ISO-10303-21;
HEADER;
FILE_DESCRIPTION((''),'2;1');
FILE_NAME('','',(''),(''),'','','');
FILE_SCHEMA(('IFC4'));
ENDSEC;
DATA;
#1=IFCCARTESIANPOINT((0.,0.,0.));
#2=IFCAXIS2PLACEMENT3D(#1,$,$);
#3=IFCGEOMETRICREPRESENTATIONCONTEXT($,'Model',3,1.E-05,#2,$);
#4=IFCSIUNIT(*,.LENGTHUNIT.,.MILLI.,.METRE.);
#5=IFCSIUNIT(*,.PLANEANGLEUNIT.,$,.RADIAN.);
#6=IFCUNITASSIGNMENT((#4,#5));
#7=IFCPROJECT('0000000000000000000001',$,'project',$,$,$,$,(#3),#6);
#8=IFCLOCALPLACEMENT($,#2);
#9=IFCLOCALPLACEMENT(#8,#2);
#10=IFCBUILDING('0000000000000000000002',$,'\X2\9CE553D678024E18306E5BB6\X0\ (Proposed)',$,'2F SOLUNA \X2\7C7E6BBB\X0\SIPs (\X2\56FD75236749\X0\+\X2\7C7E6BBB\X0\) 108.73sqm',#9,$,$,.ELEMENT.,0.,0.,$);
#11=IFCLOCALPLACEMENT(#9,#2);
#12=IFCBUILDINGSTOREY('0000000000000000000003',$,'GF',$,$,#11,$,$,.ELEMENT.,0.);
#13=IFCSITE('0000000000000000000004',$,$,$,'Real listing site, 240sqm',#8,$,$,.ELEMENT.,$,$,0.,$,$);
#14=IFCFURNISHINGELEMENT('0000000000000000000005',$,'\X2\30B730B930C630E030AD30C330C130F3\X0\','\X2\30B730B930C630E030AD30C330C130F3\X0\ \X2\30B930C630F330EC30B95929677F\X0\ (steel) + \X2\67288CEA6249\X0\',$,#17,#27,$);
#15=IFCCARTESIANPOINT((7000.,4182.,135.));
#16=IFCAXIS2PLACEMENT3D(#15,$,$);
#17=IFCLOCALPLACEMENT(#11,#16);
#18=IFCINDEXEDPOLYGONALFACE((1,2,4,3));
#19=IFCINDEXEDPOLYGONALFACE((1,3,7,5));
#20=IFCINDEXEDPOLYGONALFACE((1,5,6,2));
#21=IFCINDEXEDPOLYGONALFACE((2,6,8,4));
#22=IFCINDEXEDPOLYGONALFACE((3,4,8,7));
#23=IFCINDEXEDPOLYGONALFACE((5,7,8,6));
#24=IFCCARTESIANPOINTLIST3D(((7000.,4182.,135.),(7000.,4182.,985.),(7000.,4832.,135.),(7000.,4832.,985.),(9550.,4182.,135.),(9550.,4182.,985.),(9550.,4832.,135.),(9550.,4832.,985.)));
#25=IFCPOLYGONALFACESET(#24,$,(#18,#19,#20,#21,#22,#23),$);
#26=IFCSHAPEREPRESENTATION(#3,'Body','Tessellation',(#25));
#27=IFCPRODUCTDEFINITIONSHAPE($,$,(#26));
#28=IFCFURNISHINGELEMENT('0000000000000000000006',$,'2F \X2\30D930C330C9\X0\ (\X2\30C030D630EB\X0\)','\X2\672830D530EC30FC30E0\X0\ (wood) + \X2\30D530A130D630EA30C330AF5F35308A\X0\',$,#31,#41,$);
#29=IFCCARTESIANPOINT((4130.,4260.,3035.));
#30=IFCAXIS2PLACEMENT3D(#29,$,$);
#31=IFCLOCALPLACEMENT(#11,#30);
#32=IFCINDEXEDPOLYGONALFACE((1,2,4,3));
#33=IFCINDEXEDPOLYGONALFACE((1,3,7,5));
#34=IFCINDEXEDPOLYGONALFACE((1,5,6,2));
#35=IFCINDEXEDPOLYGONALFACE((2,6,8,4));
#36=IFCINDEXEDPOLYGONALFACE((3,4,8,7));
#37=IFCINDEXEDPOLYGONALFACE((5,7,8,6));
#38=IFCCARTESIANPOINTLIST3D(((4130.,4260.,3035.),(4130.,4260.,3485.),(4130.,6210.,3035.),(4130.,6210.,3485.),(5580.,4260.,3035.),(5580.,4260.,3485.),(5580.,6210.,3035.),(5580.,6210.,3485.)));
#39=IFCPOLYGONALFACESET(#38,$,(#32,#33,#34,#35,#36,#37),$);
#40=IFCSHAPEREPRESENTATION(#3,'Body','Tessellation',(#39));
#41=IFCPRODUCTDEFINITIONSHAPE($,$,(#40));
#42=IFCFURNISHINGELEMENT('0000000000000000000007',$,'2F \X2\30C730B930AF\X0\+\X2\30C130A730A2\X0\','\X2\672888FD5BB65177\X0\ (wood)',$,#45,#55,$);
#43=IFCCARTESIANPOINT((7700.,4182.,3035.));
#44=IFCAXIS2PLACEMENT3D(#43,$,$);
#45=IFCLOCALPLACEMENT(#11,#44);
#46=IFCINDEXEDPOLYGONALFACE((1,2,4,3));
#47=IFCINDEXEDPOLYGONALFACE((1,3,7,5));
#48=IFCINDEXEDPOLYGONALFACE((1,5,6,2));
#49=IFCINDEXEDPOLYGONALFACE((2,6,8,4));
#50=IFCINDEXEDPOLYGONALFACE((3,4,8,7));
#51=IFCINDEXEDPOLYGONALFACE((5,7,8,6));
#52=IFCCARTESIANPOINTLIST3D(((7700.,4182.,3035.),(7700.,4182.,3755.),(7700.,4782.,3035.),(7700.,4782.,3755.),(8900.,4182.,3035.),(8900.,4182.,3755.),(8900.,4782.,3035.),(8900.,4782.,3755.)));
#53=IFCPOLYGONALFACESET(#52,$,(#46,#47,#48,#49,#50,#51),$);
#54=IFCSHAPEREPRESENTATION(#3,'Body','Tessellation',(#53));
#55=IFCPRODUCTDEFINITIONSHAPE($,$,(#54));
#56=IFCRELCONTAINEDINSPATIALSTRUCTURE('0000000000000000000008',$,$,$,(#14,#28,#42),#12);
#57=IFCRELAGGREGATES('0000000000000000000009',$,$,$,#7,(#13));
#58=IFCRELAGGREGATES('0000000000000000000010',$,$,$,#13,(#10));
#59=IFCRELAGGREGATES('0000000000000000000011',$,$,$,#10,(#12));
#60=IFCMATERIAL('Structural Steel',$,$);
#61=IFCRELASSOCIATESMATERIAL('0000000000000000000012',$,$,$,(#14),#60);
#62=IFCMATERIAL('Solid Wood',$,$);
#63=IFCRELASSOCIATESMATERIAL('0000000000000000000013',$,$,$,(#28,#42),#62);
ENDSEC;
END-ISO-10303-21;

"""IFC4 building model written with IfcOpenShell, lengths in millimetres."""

from ifc_helpers import new_model, si_unit, frame, frame_2d, origin, place, context, project, spatial, rectangle, extrude, material, element, save


model = new_model("IFC4")

# Units and contexts
model_context = context("Model", 3, precision=1e-05, world=origin())
ifc_project = project(units=[si_unit("LENGTHUNIT", "METRE", prefix="MILLI"), si_unit("PLANEANGLEUNIT", "RADIAN")], contexts=[model_context])

# Site, building, storey
site_placement = place(None, origin())
site = spatial("IfcSite", under=ifc_project, at=site_placement, ObjectType="Real listing site, 240sqm", CompositionType="ELEMENT", RefElevation=0.0)
building_placement = place(site_placement, origin())
building = spatial("IfcBuilding", under=site, at=building_placement, Name="鳥取砂丘の家 (Proposed)", ObjectType="2F SOLUNA 籾殻SIPs (国産杉+籾殻) 108.73sqm", CompositionType="ELEMENT", ElevationOfRefHeight=0.0, ElevationOfTerrain=0.0)
storey_placement = place(building_placement, origin())
storey = spatial("IfcBuildingStorey", under=building, at=storey_placement, Name="GF", CompositionType="ELEMENT", Elevation=0.0)

# Shared definitions
ifc_material_1 = material(Name="Solid Wood")

# Furnishing elements
ifc_material_2 = material(Name="Structural Steel")
furnishing_1_placement = place(storey_placement, frame((7000.0, 4182.0, 135.0)))
element("IfcFurnishingElement", 1, at=furnishing_1_placement, inside=storey, material=ifc_material_2, Name="システムキッチン", Description="システムキッチン ステンレス天板 (steel) + 木質扉", context=model_context, shape_type="SweptSolid", body=[
    extrude(rectangle(XDim=2550.0, YDim=650.0, at=frame_2d((1275.0, 325.0))), frame((7000.0, 4182.0, 135.0)), (0.0, 0.0, 1.0), 850.0),
])
furnishing_2_placement = place(storey_placement, frame((4130.0, 4260.0, 3035.0)))
element("IfcFurnishingElement", 2, at=furnishing_2_placement, inside=storey, material=ifc_material_1, Name="2F ベッド (ダブル)", Description="木フレーム (wood) + ファブリック張り", context=model_context, shape_type="SweptSolid", body=[
    extrude(rectangle(XDim=1450.0, YDim=1950.0, at=frame_2d((725.0, 975.0))), frame((4130.0, 4260.0, 3035.0)), (0.0, 0.0, 1.0), 450.0),
])
furnishing_3_placement = place(storey_placement, frame((7700.0, 4182.0, 3035.0)))
element("IfcFurnishingElement", 3, at=furnishing_3_placement, inside=storey, material=ifc_material_1, Name="2F デスク+チェア", Description="木製家具 (wood)", context=model_context, shape_type="SweptSolid", body=[
    extrude(rectangle(XDim=1200.0, YDim=600.0, at=frame_2d((600.0, 300.0))), frame((7700.0, 4182.0, 3035.0)), (0.0, 0.0, 1.0), 720.0),
])

save(model, "model.ifc")
